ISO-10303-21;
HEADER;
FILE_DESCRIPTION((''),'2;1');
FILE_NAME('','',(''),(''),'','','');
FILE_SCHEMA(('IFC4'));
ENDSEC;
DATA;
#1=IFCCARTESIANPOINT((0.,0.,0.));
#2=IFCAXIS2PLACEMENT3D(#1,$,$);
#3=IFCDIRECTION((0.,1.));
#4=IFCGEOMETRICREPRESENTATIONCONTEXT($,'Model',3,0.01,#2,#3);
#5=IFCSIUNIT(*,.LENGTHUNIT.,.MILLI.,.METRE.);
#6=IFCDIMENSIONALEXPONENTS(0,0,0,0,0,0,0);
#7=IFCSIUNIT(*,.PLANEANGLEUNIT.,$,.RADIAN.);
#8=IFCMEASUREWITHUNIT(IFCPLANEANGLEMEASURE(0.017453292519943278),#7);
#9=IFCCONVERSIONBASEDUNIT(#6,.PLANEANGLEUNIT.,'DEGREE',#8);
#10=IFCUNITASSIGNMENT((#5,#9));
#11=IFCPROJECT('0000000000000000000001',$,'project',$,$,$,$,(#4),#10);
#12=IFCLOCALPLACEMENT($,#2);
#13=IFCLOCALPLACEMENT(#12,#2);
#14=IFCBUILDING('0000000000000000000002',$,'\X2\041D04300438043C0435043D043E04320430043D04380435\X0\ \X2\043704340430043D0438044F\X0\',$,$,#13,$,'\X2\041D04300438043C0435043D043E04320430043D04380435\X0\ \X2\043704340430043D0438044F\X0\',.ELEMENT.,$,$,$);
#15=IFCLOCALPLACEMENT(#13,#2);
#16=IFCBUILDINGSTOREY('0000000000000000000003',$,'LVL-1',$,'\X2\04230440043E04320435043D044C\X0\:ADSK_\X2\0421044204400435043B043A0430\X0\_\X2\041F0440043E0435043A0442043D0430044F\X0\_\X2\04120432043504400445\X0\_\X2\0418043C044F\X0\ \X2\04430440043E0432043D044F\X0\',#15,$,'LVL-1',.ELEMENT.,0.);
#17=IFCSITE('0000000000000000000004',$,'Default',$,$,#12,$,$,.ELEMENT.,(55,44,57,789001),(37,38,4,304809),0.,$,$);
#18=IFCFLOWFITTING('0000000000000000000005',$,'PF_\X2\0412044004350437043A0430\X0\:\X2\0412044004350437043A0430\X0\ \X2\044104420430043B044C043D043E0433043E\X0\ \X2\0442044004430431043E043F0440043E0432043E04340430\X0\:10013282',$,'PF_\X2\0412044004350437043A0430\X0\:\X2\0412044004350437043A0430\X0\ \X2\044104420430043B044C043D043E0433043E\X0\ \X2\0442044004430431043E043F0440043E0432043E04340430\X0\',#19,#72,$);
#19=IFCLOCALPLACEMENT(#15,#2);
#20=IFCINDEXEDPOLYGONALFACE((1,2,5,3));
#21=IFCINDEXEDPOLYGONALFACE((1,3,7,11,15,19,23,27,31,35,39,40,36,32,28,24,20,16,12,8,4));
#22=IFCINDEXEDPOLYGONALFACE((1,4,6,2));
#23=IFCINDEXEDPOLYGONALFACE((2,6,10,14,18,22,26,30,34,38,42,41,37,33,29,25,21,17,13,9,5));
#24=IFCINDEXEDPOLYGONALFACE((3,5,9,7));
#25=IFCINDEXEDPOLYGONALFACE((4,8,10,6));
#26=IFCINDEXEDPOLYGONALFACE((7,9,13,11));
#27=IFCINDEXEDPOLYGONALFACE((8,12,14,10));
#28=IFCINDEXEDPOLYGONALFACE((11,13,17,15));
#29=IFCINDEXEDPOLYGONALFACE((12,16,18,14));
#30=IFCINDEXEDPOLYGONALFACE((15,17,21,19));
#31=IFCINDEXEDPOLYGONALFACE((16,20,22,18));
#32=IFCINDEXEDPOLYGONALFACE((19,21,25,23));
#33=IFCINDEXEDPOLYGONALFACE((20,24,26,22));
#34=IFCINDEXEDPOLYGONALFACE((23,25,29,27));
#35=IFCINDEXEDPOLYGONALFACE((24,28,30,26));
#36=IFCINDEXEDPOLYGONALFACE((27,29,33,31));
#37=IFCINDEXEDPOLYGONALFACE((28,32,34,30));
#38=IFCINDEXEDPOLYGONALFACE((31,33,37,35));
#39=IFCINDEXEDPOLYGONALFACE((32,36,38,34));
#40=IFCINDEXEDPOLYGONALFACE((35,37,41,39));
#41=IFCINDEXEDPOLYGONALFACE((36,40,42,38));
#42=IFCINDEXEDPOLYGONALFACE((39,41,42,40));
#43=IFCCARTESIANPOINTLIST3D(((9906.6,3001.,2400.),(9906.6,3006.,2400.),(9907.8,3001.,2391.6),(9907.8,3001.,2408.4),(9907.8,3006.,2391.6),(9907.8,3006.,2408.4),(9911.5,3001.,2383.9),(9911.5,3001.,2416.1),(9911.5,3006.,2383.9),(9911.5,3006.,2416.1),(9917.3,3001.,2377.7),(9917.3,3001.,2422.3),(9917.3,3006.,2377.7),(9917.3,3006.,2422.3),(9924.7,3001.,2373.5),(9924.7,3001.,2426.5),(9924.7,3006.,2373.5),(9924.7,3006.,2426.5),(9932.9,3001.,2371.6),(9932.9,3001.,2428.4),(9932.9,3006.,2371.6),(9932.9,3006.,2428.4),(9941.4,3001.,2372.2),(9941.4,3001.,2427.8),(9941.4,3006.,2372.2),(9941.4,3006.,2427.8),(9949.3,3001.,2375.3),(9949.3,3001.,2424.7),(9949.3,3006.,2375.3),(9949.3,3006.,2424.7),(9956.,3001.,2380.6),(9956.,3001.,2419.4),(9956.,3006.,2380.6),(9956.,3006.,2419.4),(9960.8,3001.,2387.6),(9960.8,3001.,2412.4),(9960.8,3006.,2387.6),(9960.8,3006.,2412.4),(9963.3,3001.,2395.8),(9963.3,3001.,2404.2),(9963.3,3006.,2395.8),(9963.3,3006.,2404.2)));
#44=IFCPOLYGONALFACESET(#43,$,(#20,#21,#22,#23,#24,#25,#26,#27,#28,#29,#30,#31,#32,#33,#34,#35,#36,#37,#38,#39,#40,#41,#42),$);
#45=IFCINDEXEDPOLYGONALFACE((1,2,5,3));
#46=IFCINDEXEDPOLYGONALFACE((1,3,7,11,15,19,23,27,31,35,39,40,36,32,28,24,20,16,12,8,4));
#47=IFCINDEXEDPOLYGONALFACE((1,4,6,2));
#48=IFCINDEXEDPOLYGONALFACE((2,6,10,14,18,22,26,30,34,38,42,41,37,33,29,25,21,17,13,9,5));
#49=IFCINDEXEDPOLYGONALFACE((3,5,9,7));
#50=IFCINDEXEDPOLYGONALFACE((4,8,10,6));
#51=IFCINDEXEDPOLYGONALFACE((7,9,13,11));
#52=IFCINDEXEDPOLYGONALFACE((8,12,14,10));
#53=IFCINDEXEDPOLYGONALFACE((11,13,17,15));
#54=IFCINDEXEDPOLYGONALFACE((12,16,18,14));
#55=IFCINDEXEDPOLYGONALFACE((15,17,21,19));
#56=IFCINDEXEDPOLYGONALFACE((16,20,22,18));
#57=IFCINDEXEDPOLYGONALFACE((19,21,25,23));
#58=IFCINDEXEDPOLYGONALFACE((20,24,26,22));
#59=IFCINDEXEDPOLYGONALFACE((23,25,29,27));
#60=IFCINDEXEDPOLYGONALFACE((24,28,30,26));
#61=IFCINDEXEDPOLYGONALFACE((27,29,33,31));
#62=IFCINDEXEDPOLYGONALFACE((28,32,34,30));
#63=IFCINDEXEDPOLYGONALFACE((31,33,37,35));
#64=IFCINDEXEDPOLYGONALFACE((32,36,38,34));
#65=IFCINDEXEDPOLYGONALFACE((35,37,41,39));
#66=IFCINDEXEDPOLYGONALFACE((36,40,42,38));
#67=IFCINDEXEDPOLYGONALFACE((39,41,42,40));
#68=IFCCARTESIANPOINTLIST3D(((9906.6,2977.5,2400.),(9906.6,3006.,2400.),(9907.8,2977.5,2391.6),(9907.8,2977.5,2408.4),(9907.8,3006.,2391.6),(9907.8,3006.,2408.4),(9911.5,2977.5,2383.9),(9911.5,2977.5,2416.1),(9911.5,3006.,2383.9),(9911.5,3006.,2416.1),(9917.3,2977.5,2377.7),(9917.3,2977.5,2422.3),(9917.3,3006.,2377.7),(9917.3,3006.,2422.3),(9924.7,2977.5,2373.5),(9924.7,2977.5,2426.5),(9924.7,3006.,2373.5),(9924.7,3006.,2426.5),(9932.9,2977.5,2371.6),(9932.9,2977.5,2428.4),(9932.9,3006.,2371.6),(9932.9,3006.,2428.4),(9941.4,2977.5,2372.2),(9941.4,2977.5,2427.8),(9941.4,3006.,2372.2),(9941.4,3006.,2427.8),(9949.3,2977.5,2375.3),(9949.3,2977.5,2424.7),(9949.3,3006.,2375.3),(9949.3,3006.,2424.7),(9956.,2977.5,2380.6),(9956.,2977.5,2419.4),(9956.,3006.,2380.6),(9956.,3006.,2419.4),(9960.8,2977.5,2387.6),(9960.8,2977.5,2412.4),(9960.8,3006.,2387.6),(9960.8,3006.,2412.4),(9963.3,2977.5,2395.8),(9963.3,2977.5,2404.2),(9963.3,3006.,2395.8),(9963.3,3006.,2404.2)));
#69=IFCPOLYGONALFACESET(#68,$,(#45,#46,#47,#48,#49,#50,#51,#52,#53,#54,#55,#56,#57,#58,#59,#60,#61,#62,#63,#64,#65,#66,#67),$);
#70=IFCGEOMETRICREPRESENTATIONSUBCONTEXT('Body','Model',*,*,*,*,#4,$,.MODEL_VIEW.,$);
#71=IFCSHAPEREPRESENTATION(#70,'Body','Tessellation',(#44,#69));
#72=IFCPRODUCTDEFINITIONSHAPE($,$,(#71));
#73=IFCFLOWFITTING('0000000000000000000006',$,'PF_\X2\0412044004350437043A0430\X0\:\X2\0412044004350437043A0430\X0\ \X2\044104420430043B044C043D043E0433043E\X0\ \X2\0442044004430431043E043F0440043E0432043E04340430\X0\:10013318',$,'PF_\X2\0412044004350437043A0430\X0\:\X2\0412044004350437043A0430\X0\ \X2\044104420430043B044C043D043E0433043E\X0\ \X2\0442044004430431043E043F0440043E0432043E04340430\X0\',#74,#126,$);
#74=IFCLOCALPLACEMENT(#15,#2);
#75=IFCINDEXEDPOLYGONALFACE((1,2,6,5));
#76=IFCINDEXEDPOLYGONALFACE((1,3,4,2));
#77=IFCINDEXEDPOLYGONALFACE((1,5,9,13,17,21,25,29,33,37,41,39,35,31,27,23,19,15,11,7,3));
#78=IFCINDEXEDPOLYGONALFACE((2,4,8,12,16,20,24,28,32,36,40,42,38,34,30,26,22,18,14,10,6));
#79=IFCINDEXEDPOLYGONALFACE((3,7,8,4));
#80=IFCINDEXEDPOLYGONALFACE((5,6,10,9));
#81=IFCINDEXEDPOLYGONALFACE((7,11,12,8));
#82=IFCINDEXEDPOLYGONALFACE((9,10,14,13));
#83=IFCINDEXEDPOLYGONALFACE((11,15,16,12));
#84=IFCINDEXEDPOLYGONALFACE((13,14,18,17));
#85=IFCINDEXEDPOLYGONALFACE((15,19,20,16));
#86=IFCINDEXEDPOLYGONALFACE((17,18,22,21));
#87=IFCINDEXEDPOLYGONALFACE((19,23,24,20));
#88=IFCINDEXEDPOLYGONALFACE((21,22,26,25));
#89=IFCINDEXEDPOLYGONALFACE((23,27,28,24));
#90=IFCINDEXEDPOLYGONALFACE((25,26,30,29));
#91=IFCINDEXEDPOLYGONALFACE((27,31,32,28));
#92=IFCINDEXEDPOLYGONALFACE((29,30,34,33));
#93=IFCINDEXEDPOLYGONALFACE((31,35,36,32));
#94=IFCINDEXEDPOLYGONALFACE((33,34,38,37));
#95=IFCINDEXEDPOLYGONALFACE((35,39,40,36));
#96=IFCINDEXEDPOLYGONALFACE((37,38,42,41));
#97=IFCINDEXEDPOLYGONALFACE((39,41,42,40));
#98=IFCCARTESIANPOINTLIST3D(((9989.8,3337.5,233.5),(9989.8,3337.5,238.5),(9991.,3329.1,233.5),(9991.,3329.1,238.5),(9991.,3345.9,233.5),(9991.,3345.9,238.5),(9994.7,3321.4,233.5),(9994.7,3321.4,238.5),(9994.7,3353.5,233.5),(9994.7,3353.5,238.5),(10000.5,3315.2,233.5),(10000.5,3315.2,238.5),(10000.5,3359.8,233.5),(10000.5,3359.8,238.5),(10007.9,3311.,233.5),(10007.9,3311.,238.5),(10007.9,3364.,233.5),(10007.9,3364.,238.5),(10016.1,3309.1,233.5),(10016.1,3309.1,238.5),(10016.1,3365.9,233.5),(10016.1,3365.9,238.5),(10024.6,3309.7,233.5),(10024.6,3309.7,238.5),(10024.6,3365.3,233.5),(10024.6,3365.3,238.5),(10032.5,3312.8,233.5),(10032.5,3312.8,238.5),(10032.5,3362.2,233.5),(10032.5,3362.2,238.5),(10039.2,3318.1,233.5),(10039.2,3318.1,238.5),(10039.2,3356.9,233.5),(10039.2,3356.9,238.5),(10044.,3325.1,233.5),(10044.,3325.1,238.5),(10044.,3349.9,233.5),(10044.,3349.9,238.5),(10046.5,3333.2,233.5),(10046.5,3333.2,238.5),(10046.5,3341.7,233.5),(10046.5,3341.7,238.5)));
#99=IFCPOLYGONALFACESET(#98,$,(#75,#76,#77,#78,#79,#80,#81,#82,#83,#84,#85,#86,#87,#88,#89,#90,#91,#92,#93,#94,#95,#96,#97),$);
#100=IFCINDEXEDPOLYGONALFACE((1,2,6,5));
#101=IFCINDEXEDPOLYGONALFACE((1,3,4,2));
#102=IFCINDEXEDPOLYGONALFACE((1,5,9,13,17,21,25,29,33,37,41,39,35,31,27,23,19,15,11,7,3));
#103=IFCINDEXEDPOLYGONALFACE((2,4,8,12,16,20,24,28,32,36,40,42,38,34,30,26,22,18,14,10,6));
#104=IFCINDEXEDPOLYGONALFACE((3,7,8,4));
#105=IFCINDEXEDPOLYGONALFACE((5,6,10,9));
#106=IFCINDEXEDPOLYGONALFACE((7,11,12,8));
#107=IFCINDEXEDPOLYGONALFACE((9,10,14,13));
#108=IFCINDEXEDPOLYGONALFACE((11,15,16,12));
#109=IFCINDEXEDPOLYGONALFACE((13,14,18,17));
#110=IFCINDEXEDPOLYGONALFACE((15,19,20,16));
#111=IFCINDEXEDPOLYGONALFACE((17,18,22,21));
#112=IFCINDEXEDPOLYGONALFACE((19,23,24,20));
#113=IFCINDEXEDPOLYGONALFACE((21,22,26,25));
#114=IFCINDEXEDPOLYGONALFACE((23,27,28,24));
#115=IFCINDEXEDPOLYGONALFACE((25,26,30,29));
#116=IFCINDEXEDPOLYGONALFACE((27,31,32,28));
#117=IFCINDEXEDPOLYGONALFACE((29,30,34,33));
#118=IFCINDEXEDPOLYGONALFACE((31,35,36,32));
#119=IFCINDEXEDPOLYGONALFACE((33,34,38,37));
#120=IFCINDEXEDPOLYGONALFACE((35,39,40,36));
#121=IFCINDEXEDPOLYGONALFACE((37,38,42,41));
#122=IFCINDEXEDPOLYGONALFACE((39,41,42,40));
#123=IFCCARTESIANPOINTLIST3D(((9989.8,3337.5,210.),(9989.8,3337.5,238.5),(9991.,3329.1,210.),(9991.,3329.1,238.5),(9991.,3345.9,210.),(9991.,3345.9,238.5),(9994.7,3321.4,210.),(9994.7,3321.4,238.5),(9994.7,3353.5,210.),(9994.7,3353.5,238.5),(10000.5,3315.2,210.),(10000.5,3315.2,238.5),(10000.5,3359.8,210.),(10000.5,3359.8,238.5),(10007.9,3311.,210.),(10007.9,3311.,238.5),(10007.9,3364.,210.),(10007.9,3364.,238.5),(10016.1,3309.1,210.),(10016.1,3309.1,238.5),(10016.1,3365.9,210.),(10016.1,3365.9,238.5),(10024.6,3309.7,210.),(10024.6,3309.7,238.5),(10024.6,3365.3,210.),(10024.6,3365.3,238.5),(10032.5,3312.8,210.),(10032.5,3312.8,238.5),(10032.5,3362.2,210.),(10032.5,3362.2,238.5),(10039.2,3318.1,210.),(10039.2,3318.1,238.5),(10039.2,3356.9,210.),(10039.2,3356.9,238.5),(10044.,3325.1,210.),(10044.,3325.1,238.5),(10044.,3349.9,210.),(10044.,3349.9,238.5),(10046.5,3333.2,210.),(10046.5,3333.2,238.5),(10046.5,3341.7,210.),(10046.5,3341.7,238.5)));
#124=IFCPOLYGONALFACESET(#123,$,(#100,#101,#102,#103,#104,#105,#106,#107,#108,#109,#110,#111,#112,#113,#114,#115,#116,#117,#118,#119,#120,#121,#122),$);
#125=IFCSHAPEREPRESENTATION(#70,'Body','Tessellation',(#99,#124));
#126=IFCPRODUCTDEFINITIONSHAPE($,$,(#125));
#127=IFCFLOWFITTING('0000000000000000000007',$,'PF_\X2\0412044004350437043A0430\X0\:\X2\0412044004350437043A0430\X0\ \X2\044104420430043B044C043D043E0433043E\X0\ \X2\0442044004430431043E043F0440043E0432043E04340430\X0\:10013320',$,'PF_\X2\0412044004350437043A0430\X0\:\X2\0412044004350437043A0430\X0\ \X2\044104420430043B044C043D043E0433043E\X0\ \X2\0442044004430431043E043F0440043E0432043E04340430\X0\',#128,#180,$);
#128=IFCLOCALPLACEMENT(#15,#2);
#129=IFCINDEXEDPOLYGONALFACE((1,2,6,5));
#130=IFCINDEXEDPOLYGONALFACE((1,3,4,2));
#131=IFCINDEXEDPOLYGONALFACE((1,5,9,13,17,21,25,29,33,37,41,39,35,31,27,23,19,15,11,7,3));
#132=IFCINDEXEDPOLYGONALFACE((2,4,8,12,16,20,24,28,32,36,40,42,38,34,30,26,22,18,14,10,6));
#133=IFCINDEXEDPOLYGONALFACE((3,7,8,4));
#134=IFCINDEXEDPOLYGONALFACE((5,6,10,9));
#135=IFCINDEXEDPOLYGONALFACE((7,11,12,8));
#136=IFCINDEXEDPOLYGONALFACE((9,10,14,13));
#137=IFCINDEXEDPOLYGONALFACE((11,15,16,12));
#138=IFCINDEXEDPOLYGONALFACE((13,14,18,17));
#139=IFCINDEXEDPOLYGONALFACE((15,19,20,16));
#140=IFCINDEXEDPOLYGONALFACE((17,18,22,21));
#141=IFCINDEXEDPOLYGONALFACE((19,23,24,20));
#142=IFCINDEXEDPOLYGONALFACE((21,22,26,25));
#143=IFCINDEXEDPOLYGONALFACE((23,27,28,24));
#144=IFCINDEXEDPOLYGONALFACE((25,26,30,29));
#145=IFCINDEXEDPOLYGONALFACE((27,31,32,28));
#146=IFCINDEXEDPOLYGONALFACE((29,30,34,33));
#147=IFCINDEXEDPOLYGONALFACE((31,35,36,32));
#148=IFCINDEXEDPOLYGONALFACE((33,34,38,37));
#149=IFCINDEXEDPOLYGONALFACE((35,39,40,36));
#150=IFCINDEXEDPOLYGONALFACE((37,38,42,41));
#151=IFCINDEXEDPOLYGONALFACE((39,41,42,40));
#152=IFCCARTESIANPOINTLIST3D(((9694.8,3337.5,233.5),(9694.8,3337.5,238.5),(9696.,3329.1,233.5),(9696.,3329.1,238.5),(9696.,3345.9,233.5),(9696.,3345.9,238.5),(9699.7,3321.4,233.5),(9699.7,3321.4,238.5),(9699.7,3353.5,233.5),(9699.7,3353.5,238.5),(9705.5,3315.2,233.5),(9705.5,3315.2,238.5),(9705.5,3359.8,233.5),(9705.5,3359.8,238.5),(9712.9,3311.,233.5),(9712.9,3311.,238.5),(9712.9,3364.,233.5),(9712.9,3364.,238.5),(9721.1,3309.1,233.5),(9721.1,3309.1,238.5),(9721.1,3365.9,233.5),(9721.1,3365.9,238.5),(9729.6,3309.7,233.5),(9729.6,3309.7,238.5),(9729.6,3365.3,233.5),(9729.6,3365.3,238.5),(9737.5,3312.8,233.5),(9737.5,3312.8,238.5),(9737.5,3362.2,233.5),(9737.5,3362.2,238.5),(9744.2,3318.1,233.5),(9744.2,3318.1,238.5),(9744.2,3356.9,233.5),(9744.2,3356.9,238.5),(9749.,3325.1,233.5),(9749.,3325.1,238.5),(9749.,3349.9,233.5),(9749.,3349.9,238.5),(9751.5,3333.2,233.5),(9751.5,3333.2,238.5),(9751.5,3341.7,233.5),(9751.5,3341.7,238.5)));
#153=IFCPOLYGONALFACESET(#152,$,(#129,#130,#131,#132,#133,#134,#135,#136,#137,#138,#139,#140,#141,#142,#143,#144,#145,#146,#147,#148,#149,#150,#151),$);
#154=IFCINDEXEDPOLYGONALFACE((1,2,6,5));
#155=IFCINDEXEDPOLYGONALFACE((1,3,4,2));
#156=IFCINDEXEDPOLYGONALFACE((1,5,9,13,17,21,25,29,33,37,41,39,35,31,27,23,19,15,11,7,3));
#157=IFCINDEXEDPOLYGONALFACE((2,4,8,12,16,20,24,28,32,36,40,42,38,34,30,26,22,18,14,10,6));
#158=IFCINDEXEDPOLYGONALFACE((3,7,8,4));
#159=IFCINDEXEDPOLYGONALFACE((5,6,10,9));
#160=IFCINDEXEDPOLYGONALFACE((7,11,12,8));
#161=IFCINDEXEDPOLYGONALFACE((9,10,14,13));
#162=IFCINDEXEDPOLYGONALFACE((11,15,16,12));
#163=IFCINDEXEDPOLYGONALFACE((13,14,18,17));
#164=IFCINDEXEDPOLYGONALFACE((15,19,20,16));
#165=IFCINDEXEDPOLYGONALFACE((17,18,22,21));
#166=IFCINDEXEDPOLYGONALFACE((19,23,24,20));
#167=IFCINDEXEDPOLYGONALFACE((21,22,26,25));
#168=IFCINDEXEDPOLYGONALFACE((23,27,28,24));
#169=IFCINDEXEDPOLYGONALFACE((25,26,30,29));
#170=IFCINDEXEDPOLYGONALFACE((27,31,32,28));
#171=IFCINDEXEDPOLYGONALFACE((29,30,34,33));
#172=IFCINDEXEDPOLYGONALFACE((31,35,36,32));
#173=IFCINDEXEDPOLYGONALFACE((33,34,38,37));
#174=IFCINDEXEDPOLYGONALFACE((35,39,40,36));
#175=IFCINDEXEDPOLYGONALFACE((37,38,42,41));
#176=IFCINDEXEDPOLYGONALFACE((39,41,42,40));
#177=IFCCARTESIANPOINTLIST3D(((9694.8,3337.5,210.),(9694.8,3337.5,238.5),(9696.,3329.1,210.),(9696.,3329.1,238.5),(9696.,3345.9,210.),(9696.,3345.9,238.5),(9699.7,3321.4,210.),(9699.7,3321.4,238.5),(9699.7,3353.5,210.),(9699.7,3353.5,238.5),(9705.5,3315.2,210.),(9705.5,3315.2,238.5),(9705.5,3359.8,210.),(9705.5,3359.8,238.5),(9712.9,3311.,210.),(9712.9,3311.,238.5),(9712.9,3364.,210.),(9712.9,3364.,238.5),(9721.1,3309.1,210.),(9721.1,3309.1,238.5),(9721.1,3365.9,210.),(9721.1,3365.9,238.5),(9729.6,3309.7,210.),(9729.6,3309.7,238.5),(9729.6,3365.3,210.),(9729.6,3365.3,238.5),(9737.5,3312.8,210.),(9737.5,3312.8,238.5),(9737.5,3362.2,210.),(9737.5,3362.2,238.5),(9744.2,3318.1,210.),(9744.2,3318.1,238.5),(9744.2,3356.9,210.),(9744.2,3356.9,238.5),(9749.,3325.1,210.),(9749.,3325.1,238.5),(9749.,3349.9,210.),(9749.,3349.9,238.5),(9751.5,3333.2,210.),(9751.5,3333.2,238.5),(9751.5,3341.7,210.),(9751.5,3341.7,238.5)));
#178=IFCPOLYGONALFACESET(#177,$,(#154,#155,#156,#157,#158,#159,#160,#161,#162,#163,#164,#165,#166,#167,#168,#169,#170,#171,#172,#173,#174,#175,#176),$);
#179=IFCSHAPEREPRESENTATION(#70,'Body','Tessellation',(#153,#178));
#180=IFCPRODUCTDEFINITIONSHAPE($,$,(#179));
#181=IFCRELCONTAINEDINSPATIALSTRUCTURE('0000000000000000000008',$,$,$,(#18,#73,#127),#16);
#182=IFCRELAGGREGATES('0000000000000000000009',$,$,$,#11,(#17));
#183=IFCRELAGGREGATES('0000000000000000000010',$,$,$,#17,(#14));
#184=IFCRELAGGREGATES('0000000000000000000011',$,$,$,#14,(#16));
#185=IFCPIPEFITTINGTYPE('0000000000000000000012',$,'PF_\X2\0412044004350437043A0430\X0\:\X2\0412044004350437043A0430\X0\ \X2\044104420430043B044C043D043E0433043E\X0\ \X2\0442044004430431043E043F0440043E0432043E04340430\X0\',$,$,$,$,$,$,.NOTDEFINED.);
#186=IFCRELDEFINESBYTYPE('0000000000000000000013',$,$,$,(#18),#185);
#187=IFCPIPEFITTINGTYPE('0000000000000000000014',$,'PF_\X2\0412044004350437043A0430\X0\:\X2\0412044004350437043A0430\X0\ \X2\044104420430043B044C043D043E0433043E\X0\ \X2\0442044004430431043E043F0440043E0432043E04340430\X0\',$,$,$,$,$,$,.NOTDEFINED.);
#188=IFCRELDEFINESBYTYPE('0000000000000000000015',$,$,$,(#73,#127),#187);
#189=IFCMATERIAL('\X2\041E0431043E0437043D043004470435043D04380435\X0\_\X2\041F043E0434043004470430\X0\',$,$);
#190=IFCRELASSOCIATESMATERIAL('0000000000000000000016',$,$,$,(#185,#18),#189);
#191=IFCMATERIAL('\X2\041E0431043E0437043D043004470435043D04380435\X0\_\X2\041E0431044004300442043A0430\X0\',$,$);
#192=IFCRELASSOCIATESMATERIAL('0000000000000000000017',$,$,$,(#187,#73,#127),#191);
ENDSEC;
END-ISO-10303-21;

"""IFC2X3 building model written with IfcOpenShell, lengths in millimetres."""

from ifc_helpers import new_model, entity, si_unit, converted_unit, direction, frame, frame_2d, origin, place, context, subcontext, project, spatial, circle, extrude, source, transform, mapped, material, type_object, type_shapes, element, save


model = new_model("IFC2X3")

# Units and contexts
model_context = context("Model", 3, precision=0.01, world=origin(), true_north=direction((0.0, 1.0)))
body_context = subcontext(model_context, "Body", "Model", "MODEL_VIEW")
ifc_project = project(units=[si_unit("LENGTHUNIT", "METRE", prefix="MILLI"), converted_unit("PLANEANGLEUNIT", "DEGREE", entity("IfcPlaneAngleMeasure", 0.017453292519943278), si_unit("PLANEANGLEUNIT", "RADIAN"), dimensions=[0, 0, 0, 0, 0, 0, 0])], contexts=[model_context])

# Site, building, storey
site_placement = place(None, origin())
site = spatial("IfcSite", under=ifc_project, at=site_placement, Name="Default", CompositionType="ELEMENT", RefLatitude=(55, 44, 57, 789001), RefLongitude=(37, 38, 4, 304809), RefElevation=0.0)
building_placement = place(site_placement, origin())
building = spatial("IfcBuilding", under=site, at=building_placement, Name="Наименование здания", LongName="Наименование здания", CompositionType="ELEMENT")
storey_placement = place(building_placement, origin())
storey = spatial("IfcBuildingStorey", under=building, at=storey_placement, Name="LVL-1", ObjectType="Уровень:ADSK_Стрелка_Проектная_Вверх_Имя уровня", LongName="LVL-1", CompositionType="ELEMENT", Elevation=0.0)

# Shared definitions
ifc_material_1 = material(Name="Обозначение_Подача")

# Flow fittings
pipe_fitting_type_1 = type_object("IfcPipeFittingType", Name="PF_Врезка:Врезка стального трубопровода", PredefinedType="NOTDEFINED", material=ifc_material_1)
shared_shape_1 = source(origin(), body_context, "Body", "SweptSolid", [
    extrude(circle(Radius=28.5, at=frame_2d((0.0, 0.0), x_axis=(1.0, 0.0))), frame((-5.0, 0.0, 0.0), z_axis=(1.0, 0.0, 0.0), x_axis=(0.0, -1.0, 0.0)), (0.0, 0.0, 1.0), 5.0),
    extrude(circle(Radius=28.5, at=frame_2d((0.0, 0.0), x_axis=(1.0, 0.0))), frame((-28.5, 0.0, 0.0), z_axis=(1.0, 0.0, 0.0), x_axis=(0.0, -1.0, 0.0)), (0.0, 0.0, 1.0), 28.5),
])
type_shapes(pipe_fitting_type_1, [shared_shape_1])
flow_fitting_1_placement = place(storey_placement, frame((9935.1, 3006.0, 2400.0), z_axis=(0.0, 0.0, -1.0), x_axis=(0.0, 1.0, 0.0)))
element("IfcFlowFitting", 1, at=flow_fitting_1_placement, inside=storey, type_object=pipe_fitting_type_1, material=ifc_material_1, Name="PF_Врезка:Врезка стального трубопровода:10013282", ObjectType="PF_Врезка:Врезка стального трубопровода", context=body_context, shape_type="MappedRepresentation", body=[
    mapped(shared_shape_1, transform((0.0, 0.0, 0.0), scale=1.0)),
])
ifc_material_2 = material(Name="Обозначение_Обратка")
pipe_fitting_type_2 = type_object("IfcPipeFittingType", Name="PF_Врезка:Врезка стального трубопровода", PredefinedType="NOTDEFINED", material=ifc_material_2)
shared_shape_2 = source(origin(), body_context, "Body", "SweptSolid", [
    extrude(circle(Radius=28.5, at=frame_2d((0.0, 0.0), x_axis=(1.0, 0.0))), frame((-5.0, 0.0, 0.0), z_axis=(1.0, 0.0, 0.0), x_axis=(0.0, 1.0, 0.0)), (0.0, 0.0, 1.0), 5.0),
    extrude(circle(Radius=28.5, at=frame_2d((0.0, 0.0), x_axis=(1.0, 0.0))), frame((-28.5, 0.0, 0.0), z_axis=(1.0, 0.0, 0.0), x_axis=(0.0, 1.0, 0.0)), (0.0, 0.0, 1.0), 28.5),
])
type_shapes(pipe_fitting_type_2, [shared_shape_2])
for number, where, z_axis, x_axis, name in (
    (2, (10018.3, 3337.5, 238.5), (0.0, -1.0, 0.0), (0.0, 0.0, 1.0), "PF_Врезка:Врезка стального трубопровода:10013318"),
    (3, (9723.3, 3337.5, 238.5), (0.0, -1.0, 0.0), (0.0, 0.0, 1.0), "PF_Врезка:Врезка стального трубопровода:10013320"),
):
    element("IfcFlowFitting", number, at=place(storey_placement, frame(where, z_axis=z_axis, x_axis=x_axis)), inside=storey, type_object=pipe_fitting_type_2, material=ifc_material_2, Name=name, ObjectType="PF_Врезка:Врезка стального трубопровода", context=body_context, shape_type="MappedRepresentation", body=[
        mapped(shared_shape_2, transform((0.0, 0.0, 0.0), scale=1.0)),
    ])

save(model, "model.ifc")
